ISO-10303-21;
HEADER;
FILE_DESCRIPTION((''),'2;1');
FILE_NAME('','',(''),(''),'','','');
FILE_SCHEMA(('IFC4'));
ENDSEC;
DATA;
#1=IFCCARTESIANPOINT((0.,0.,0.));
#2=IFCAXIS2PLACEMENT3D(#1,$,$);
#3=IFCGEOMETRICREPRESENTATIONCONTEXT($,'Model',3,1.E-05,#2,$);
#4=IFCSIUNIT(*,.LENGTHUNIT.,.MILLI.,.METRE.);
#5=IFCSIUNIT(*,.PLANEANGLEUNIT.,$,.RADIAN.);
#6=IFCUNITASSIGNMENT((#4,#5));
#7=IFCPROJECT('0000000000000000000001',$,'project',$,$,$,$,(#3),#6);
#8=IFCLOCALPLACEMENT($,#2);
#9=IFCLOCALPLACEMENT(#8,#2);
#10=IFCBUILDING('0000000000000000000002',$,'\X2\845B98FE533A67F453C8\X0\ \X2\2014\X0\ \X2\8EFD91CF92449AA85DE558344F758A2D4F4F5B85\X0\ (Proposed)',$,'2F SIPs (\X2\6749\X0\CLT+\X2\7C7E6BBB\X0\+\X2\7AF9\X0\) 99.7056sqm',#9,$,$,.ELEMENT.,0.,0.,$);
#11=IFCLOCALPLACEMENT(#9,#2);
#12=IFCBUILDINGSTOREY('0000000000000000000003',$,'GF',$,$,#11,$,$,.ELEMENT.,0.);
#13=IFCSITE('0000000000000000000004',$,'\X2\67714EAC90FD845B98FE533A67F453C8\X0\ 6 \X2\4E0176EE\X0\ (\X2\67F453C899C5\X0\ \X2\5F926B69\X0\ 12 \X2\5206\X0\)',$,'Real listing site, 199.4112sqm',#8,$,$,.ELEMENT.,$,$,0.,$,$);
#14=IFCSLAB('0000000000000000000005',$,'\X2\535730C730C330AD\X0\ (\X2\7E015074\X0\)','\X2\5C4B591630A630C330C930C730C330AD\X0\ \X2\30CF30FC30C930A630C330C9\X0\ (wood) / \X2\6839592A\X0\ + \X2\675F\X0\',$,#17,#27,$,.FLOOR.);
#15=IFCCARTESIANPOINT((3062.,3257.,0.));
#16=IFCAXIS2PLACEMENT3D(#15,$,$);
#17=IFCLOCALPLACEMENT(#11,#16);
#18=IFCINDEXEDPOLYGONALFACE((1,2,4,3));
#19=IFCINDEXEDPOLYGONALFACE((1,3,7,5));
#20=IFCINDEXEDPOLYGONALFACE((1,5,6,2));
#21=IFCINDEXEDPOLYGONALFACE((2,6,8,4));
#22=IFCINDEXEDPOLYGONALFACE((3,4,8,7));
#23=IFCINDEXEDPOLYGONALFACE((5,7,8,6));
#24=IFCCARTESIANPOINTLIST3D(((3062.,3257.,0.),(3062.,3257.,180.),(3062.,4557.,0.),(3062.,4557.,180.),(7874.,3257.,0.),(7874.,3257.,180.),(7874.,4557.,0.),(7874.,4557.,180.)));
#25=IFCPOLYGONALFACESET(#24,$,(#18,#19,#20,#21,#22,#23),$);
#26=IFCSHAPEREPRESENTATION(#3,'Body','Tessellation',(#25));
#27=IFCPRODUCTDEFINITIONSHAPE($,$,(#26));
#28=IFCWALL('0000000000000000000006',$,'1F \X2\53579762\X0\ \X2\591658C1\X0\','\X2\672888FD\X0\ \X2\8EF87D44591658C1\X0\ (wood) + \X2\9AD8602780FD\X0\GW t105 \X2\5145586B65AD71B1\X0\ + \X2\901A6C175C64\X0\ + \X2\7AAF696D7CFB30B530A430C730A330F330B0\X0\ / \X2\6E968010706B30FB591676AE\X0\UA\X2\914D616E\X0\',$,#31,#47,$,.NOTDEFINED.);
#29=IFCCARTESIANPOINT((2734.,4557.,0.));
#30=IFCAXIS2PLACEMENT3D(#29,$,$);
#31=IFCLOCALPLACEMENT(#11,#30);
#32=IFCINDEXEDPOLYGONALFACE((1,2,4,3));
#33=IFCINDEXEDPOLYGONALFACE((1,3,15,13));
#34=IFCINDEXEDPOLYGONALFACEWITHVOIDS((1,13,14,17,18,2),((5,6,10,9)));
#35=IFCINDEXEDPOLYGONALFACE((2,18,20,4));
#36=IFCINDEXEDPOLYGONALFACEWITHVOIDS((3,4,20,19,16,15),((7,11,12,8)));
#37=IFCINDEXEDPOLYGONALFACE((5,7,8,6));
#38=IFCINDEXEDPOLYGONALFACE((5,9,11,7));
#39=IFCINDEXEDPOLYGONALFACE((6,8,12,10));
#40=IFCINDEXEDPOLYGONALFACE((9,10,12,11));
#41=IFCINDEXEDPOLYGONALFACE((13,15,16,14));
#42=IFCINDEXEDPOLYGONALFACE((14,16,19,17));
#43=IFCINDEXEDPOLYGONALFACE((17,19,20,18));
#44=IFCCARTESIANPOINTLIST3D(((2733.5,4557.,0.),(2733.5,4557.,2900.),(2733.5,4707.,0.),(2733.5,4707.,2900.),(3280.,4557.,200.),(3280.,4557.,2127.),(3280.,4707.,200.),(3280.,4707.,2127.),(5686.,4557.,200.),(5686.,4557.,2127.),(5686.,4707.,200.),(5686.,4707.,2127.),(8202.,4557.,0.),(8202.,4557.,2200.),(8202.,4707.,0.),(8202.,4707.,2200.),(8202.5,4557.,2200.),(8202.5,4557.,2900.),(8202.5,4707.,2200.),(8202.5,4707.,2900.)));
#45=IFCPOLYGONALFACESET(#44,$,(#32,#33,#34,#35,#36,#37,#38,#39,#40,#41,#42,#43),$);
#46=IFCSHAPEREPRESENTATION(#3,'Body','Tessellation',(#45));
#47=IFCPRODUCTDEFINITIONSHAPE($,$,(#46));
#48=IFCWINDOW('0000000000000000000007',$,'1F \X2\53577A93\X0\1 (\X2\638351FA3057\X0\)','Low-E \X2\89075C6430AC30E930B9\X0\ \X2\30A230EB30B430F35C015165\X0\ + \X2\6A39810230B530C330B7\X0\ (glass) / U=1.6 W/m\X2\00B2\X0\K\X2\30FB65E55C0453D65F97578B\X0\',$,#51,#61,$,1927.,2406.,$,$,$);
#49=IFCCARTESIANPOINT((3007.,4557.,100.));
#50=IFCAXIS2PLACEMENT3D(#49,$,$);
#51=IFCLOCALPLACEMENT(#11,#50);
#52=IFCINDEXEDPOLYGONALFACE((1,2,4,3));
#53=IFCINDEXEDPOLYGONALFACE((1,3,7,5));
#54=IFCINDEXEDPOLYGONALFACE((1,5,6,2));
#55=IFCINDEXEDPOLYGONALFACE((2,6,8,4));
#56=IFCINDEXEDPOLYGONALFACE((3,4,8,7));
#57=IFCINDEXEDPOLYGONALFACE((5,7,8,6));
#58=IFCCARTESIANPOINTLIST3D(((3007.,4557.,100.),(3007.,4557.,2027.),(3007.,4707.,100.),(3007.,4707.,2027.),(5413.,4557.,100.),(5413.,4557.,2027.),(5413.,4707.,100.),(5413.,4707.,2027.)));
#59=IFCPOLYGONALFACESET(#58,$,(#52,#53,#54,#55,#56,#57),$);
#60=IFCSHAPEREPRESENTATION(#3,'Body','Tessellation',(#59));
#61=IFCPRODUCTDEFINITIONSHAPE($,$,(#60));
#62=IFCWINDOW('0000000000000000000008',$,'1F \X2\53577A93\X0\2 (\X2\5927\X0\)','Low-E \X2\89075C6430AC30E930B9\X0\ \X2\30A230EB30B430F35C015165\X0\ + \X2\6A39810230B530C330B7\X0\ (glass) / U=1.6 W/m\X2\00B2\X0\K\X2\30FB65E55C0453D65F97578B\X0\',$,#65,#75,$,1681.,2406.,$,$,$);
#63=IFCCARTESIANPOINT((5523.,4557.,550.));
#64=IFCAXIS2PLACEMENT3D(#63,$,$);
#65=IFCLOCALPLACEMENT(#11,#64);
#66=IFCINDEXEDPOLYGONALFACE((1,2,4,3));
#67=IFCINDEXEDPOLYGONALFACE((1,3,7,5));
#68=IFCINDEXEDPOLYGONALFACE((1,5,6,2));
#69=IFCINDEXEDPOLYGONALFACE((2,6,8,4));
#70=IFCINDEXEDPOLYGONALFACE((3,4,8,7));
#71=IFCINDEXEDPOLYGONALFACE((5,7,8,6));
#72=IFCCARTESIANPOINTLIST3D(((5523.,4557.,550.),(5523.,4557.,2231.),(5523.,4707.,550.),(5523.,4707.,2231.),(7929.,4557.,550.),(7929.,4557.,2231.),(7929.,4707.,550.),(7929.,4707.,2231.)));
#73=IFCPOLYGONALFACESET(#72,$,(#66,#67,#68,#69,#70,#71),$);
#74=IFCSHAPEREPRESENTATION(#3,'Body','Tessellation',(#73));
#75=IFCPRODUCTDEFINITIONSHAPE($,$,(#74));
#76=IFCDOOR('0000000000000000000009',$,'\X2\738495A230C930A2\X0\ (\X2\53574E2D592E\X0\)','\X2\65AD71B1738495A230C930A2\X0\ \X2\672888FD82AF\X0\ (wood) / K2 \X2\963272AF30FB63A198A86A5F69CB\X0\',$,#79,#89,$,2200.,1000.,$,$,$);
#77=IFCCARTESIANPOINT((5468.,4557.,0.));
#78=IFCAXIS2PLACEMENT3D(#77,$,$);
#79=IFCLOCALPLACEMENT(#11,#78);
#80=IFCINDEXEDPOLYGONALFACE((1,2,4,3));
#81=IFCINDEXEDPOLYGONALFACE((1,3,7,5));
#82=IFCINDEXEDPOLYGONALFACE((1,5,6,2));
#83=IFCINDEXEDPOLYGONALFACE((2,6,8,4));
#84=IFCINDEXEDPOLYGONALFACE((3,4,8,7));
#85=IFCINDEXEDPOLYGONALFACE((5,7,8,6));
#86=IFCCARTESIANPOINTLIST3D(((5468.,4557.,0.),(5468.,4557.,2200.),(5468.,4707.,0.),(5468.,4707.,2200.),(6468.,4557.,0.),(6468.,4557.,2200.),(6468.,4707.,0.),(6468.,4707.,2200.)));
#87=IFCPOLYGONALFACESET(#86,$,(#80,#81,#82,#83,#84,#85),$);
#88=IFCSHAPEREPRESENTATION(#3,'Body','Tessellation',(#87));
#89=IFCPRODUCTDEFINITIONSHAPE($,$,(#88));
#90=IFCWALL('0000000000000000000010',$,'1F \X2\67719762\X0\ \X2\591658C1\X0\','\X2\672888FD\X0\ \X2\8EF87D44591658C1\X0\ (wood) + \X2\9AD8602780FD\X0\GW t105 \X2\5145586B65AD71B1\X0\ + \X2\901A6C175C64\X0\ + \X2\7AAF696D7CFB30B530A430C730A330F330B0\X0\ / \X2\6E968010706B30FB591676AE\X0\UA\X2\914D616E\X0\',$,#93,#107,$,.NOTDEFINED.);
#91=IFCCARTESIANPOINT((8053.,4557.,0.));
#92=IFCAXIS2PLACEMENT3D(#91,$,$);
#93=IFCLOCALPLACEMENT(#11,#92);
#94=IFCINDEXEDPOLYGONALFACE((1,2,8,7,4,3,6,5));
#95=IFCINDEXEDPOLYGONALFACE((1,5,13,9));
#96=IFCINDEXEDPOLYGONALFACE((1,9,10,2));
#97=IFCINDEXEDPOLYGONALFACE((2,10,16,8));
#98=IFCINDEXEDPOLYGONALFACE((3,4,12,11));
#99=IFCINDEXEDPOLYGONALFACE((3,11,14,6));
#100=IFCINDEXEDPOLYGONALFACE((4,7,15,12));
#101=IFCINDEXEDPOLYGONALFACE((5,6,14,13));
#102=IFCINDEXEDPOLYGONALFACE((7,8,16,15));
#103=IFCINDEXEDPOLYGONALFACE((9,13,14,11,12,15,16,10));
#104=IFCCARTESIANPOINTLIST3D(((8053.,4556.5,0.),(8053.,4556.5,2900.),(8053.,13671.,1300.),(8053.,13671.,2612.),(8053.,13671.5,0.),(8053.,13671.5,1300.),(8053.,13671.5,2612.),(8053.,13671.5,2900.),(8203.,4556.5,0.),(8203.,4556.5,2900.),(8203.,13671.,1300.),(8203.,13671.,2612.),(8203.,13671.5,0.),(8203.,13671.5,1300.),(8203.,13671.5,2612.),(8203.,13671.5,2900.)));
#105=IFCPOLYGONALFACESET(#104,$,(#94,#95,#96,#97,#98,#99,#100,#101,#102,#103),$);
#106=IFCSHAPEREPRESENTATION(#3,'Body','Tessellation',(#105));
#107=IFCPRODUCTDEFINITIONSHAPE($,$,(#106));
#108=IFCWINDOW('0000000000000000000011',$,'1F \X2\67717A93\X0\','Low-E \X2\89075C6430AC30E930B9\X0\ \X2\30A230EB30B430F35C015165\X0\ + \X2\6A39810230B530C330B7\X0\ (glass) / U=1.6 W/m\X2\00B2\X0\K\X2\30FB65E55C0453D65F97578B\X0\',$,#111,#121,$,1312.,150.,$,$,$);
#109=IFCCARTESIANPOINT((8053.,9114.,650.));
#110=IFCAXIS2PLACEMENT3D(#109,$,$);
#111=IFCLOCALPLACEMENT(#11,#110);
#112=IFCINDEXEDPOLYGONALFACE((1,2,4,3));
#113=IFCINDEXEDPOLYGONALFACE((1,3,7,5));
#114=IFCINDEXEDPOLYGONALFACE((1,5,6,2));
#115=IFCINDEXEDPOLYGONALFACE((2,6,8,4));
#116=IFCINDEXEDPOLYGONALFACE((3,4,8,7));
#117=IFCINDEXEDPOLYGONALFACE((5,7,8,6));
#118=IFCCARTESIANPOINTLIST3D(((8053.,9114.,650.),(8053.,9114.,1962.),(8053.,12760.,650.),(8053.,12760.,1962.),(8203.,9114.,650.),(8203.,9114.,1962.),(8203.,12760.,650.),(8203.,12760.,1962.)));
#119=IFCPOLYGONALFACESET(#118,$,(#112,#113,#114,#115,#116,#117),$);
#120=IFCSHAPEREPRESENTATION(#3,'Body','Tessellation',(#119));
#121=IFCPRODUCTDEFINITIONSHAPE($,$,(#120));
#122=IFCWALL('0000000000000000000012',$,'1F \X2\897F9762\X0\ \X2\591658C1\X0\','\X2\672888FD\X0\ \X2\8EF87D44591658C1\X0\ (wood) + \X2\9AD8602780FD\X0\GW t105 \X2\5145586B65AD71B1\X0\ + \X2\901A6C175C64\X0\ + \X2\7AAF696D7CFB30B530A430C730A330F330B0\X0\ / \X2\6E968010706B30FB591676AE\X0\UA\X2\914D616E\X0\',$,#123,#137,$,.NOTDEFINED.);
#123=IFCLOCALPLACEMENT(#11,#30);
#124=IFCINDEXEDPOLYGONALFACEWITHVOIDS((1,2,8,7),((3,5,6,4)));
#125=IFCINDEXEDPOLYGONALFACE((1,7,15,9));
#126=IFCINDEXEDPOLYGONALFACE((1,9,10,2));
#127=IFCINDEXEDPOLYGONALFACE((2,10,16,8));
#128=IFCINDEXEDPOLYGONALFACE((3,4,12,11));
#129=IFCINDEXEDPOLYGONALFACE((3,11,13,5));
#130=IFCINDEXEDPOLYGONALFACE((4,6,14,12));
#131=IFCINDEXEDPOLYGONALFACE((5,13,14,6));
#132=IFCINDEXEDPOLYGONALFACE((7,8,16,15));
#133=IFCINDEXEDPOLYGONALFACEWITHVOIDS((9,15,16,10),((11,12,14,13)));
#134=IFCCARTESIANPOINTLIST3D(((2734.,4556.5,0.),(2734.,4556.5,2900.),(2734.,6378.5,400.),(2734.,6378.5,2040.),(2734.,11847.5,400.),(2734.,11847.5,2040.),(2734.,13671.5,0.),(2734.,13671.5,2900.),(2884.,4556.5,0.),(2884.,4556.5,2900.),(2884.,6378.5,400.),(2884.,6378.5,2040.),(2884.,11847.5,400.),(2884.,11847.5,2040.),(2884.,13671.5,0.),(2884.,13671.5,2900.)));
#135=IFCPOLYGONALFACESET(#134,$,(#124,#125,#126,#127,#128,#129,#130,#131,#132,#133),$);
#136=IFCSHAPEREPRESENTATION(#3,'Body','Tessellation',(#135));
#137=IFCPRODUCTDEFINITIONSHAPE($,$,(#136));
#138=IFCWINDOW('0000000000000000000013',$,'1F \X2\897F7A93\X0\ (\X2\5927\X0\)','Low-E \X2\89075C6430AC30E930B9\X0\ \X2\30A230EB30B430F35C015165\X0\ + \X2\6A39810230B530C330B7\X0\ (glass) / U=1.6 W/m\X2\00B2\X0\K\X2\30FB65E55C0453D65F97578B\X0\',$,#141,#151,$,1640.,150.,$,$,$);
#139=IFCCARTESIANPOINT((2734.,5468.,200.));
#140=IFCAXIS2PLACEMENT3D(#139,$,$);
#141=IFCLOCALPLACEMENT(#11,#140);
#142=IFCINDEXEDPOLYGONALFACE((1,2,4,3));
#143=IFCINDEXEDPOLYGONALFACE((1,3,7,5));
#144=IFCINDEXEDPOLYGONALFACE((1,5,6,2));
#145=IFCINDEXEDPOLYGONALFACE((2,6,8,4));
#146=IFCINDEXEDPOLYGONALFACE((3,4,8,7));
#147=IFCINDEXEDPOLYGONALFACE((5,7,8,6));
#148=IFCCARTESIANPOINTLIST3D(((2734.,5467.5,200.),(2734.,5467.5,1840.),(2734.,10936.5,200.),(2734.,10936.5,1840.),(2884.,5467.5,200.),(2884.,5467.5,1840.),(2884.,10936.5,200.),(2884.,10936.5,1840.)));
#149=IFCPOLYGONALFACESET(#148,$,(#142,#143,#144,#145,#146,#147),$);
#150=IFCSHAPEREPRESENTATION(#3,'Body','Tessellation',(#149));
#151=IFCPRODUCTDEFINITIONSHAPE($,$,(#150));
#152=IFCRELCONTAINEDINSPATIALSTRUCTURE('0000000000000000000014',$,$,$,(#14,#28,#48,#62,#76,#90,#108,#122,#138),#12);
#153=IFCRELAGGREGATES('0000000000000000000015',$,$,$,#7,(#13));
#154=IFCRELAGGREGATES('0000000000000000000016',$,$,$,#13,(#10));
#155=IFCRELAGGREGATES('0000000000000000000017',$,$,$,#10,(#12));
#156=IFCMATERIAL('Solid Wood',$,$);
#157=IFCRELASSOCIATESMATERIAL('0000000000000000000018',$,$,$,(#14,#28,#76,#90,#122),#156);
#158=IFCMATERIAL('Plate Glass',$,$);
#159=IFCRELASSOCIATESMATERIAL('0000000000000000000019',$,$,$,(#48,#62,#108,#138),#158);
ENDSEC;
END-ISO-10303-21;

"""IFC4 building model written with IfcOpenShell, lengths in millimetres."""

from ifc_helpers import new_model, si_unit, frame, frame_2d, origin, place, context, project, spatial, rectangle, extrude, material, element, fill, save


model = new_model("IFC4")

# Units and contexts
model_context = context("Model", 3, precision=1e-05, world=origin())
ifc_project = project(units=[si_unit("LENGTHUNIT", "METRE", prefix="MILLI"), si_unit("PLANEANGLEUNIT", "RADIAN")], contexts=[model_context])

# Site, building, storey
site_placement = place(None, origin())
site = spatial("IfcSite", under=ifc_project, at=site_placement, Name="東京都葛飾区柴又 6 丁目 (柴又駅 徒歩 12 分)", ObjectType="Real listing site, 199.4112sqm", CompositionType="ELEMENT", RefElevation=0.0)
building_placement = place(site_placement, origin())
building = spatial("IfcBuilding", under=site, at=building_placement, Name="葛飾区柴又 — 軽量鉄骨工場併設住宅 (Proposed)", ObjectType="2F SIPs (杉CLT+籾殻+竹) 99.7056sqm", CompositionType="ELEMENT", ElevationOfRefHeight=0.0, ElevationOfTerrain=0.0)
storey_placement = place(building_placement, origin())
storey = spatial("IfcBuildingStorey", under=building, at=storey_placement, Name="GF", CompositionType="ELEMENT", Elevation=0.0)

# Slab
ifc_material_1 = material(Name="Solid Wood")
slab_1_placement = place(storey_placement, frame((3062.0, 3257.0, 0.0)))
element("IfcSlab", 1, at=slab_1_placement, inside=storey, material=ifc_material_1, Name="南デッキ (縁側)", Description="屋外ウッドデッキ ハードウッド (wood) / 根太 + 束", PredefinedType="FLOOR", context=model_context, shape_type="SweptSolid", body=[
    extrude(rectangle(XDim=4812.0, YDim=1300.0, at=frame_2d((2406.0, 650.0))), frame((3062.0, 3257.0, 0.0)), (0.0, 0.0, 1.0), 180.0),
])

# Wall, openings, windows, door
wall_1_placement = place(storey_placement, frame((2734.0, 4557.0, 0.0)))
wall_1 = element("IfcWall", 2, at=wall_1_placement, inside=storey, material=ifc_material_1, Name="1F 南面 外壁", Description="木製 軸組外壁 (wood) + 高性能GW t105 充填断熱 + 通気層 + 窯業系サイディング / 準耐火・外皮UA配慮", PredefinedType="NOTDEFINED", context=model_context, shape_type="SweptSolid", body=[
    extrude(rectangle(XDim=5469.0, YDim=150.0, at=frame_2d((2734.0, 75.0))), frame((2734.0, 4557.0, 0.0)), (0.0, 0.0, 1.0), 2900.0),
])
opening_1_placement = place(storey_placement, frame((3007.0, 4557.0, 100.0)))
opening_1 = element("IfcOpeningElement", 3, at=opening_1_placement, cuts=wall_1, PredefinedType="NOTDEFINED", context=model_context, shape_type="SweptSolid", body=[
    extrude(rectangle(XDim=2406.0, YDim=150.0, at=frame_2d((1203.0, 75.0))), frame((3007.0, 4557.0, 100.0)), (0.0, 0.0, 1.0), 1927.0),
])
opening_2_placement = place(storey_placement, frame((5523.0, 4557.0, 550.0)))
opening_2 = element("IfcOpeningElement", 4, at=opening_2_placement, cuts=wall_1, PredefinedType="NOTDEFINED", context=model_context, shape_type="SweptSolid", body=[
    extrude(rectangle(XDim=2406.0, YDim=150.0, at=frame_2d((1203.0, 75.0))), frame((5523.0, 4557.0, 550.0)), (0.0, 0.0, 1.0), 1681.0),
])
opening_3_placement = place(storey_placement, frame((5468.0, 4557.0, 0.0)))
opening_3 = element("IfcOpeningElement", 5, at=opening_3_placement, cuts=wall_1, PredefinedType="NOTDEFINED", context=model_context, shape_type="SweptSolid", body=[
    extrude(rectangle(XDim=1000.0, YDim=150.0, at=frame_2d((500.0, 75.0))), frame((5468.0, 4557.0, 0.0)), (0.0, 0.0, 1.0), 2200.0),
])
ifc_material_2 = material(Name="Plate Glass")
window_1_placement = place(storey_placement, frame((3007.0, 4557.0, 100.0)))
window_1 = element("IfcWindow", 6, at=window_1_placement, inside=storey, material=ifc_material_2, Name="1F 南窓1 (掃出し)", Description="Low-E 複層ガラス アルゴン封入 + 樹脂サッシ (glass) / U=1.6 W/m²K・日射取得型", OverallHeight=1927.0, OverallWidth=2406.0, context=model_context, shape_type="SweptSolid", body=[
    extrude(rectangle(XDim=2406.0, YDim=150.0, at=frame_2d((1203.0, 75.0))), frame((3007.0, 4557.0, 100.0)), (0.0, 0.0, 1.0), 1927.0),
])
fill(opening_1, window_1)
window_2_placement = place(storey_placement, frame((5523.0, 4557.0, 550.0)))
window_2 = element("IfcWindow", 7, at=window_2_placement, inside=storey, material=ifc_material_2, Name="1F 南窓2 (大)", Description="Low-E 複層ガラス アルゴン封入 + 樹脂サッシ (glass) / U=1.6 W/m²K・日射取得型", OverallHeight=1681.0, OverallWidth=2406.0, context=model_context, shape_type="SweptSolid", body=[
    extrude(rectangle(XDim=2406.0, YDim=150.0, at=frame_2d((1203.0, 75.0))), frame((5523.0, 4557.0, 550.0)), (0.0, 0.0, 1.0), 1681.0),
])
fill(opening_2, window_2)
door_placement = place(storey_placement, frame((5468.0, 4557.0, 0.0)))
door = element("IfcDoor", 8, at=door_placement, inside=storey, material=ifc_material_1, Name="玄関ドア (南中央)", Description="断熱玄関ドア 木製芯 (wood) / K2 防犯・採風機構", OverallHeight=2200.0, OverallWidth=1000.0, context=model_context, shape_type="SweptSolid", body=[
    extrude(rectangle(XDim=1000.0, YDim=150.0, at=frame_2d((500.0, 75.0))), frame((5468.0, 4557.0, 0.0)), (0.0, 0.0, 1.0), 2200.0),
])
fill(opening_3, door)

# Walls, openings, windows
wall_2_placement = place(storey_placement, frame((8053.0, 4557.0, 0.0)))
wall_2 = element("IfcWall", 9, at=wall_2_placement, inside=storey, material=ifc_material_1, Name="1F 東面 外壁", Description="木製 軸組外壁 (wood) + 高性能GW t105 充填断熱 + 通気層 + 窯業系サイディング / 準耐火・外皮UA配慮", PredefinedType="NOTDEFINED", context=model_context, shape_type="SweptSolid", body=[
    extrude(rectangle(XDim=150.0, YDim=9115.0, at=frame_2d((75.0, 4557.0))), frame((8053.0, 4557.0, 0.0)), (0.0, 0.0, 1.0), 2900.0),
])
opening_4_placement = place(storey_placement, frame((8053.0, 9114.0, 650.0)))
opening_4 = element("IfcOpeningElement", 10, at=opening_4_placement, cuts=wall_2, PredefinedType="NOTDEFINED", context=model_context, shape_type="SweptSolid", body=[
    extrude(rectangle(XDim=150.0, YDim=3646.0, at=frame_2d((75.0, 1823.0))), frame((8053.0, 9114.0, 650.0)), (0.0, 0.0, 1.0), 1312.0),
])
window_3_placement = place(storey_placement, frame((8053.0, 9114.0, 650.0)))
window_3 = element("IfcWindow", 11, at=window_3_placement, inside=storey, material=ifc_material_2, Name="1F 東窓", Description="Low-E 複層ガラス アルゴン封入 + 樹脂サッシ (glass) / U=1.6 W/m²K・日射取得型", OverallHeight=1312.0, OverallWidth=150.0, context=model_context, shape_type="SweptSolid", body=[
    extrude(rectangle(XDim=150.0, YDim=3646.0, at=frame_2d((75.0, 1823.0))), frame((8053.0, 9114.0, 650.0)), (0.0, 0.0, 1.0), 1312.0),
])
fill(opening_4, window_3)
wall_3_placement = place(storey_placement, frame((2734.0, 4557.0, 0.0)))
wall_3 = element("IfcWall", 12, at=wall_3_placement, inside=storey, material=ifc_material_1, Name="1F 西面 外壁", Description="木製 軸組外壁 (wood) + 高性能GW t105 充填断熱 + 通気層 + 窯業系サイディング / 準耐火・外皮UA配慮", PredefinedType="NOTDEFINED", context=model_context, shape_type="SweptSolid", body=[
    extrude(rectangle(XDim=150.0, YDim=9115.0, at=frame_2d((75.0, 4557.0))), frame((2734.0, 4557.0, 0.0)), (0.0, 0.0, 1.0), 2900.0),
])
opening_5_placement = place(storey_placement, frame((2734.0, 5468.0, 200.0)))
opening_5 = element("IfcOpeningElement", 13, at=opening_5_placement, cuts=wall_3, PredefinedType="NOTDEFINED", context=model_context, shape_type="SweptSolid", body=[
    extrude(rectangle(XDim=150.0, YDim=5469.0, at=frame_2d((75.0, 2734.0))), frame((2734.0, 5468.0, 200.0)), (0.0, 0.0, 1.0), 1640.0),
])
window_4_placement = place(storey_placement, frame((2734.0, 5468.0, 200.0)))
window_4 = element("IfcWindow", 14, at=window_4_placement, inside=storey, material=ifc_material_2, Name="1F 西窓 (大)", Description="Low-E 複層ガラス アルゴン封入 + 樹脂サッシ (glass) / U=1.6 W/m²K・日射取得型", OverallHeight=1640.0, OverallWidth=150.0, context=model_context, shape_type="SweptSolid", body=[
    extrude(rectangle(XDim=150.0, YDim=5469.0, at=frame_2d((75.0, 2734.0))), frame((2734.0, 5468.0, 200.0)), (0.0, 0.0, 1.0), 1640.0),
])
fill(opening_5, window_4)

save(model, "model.ifc")
